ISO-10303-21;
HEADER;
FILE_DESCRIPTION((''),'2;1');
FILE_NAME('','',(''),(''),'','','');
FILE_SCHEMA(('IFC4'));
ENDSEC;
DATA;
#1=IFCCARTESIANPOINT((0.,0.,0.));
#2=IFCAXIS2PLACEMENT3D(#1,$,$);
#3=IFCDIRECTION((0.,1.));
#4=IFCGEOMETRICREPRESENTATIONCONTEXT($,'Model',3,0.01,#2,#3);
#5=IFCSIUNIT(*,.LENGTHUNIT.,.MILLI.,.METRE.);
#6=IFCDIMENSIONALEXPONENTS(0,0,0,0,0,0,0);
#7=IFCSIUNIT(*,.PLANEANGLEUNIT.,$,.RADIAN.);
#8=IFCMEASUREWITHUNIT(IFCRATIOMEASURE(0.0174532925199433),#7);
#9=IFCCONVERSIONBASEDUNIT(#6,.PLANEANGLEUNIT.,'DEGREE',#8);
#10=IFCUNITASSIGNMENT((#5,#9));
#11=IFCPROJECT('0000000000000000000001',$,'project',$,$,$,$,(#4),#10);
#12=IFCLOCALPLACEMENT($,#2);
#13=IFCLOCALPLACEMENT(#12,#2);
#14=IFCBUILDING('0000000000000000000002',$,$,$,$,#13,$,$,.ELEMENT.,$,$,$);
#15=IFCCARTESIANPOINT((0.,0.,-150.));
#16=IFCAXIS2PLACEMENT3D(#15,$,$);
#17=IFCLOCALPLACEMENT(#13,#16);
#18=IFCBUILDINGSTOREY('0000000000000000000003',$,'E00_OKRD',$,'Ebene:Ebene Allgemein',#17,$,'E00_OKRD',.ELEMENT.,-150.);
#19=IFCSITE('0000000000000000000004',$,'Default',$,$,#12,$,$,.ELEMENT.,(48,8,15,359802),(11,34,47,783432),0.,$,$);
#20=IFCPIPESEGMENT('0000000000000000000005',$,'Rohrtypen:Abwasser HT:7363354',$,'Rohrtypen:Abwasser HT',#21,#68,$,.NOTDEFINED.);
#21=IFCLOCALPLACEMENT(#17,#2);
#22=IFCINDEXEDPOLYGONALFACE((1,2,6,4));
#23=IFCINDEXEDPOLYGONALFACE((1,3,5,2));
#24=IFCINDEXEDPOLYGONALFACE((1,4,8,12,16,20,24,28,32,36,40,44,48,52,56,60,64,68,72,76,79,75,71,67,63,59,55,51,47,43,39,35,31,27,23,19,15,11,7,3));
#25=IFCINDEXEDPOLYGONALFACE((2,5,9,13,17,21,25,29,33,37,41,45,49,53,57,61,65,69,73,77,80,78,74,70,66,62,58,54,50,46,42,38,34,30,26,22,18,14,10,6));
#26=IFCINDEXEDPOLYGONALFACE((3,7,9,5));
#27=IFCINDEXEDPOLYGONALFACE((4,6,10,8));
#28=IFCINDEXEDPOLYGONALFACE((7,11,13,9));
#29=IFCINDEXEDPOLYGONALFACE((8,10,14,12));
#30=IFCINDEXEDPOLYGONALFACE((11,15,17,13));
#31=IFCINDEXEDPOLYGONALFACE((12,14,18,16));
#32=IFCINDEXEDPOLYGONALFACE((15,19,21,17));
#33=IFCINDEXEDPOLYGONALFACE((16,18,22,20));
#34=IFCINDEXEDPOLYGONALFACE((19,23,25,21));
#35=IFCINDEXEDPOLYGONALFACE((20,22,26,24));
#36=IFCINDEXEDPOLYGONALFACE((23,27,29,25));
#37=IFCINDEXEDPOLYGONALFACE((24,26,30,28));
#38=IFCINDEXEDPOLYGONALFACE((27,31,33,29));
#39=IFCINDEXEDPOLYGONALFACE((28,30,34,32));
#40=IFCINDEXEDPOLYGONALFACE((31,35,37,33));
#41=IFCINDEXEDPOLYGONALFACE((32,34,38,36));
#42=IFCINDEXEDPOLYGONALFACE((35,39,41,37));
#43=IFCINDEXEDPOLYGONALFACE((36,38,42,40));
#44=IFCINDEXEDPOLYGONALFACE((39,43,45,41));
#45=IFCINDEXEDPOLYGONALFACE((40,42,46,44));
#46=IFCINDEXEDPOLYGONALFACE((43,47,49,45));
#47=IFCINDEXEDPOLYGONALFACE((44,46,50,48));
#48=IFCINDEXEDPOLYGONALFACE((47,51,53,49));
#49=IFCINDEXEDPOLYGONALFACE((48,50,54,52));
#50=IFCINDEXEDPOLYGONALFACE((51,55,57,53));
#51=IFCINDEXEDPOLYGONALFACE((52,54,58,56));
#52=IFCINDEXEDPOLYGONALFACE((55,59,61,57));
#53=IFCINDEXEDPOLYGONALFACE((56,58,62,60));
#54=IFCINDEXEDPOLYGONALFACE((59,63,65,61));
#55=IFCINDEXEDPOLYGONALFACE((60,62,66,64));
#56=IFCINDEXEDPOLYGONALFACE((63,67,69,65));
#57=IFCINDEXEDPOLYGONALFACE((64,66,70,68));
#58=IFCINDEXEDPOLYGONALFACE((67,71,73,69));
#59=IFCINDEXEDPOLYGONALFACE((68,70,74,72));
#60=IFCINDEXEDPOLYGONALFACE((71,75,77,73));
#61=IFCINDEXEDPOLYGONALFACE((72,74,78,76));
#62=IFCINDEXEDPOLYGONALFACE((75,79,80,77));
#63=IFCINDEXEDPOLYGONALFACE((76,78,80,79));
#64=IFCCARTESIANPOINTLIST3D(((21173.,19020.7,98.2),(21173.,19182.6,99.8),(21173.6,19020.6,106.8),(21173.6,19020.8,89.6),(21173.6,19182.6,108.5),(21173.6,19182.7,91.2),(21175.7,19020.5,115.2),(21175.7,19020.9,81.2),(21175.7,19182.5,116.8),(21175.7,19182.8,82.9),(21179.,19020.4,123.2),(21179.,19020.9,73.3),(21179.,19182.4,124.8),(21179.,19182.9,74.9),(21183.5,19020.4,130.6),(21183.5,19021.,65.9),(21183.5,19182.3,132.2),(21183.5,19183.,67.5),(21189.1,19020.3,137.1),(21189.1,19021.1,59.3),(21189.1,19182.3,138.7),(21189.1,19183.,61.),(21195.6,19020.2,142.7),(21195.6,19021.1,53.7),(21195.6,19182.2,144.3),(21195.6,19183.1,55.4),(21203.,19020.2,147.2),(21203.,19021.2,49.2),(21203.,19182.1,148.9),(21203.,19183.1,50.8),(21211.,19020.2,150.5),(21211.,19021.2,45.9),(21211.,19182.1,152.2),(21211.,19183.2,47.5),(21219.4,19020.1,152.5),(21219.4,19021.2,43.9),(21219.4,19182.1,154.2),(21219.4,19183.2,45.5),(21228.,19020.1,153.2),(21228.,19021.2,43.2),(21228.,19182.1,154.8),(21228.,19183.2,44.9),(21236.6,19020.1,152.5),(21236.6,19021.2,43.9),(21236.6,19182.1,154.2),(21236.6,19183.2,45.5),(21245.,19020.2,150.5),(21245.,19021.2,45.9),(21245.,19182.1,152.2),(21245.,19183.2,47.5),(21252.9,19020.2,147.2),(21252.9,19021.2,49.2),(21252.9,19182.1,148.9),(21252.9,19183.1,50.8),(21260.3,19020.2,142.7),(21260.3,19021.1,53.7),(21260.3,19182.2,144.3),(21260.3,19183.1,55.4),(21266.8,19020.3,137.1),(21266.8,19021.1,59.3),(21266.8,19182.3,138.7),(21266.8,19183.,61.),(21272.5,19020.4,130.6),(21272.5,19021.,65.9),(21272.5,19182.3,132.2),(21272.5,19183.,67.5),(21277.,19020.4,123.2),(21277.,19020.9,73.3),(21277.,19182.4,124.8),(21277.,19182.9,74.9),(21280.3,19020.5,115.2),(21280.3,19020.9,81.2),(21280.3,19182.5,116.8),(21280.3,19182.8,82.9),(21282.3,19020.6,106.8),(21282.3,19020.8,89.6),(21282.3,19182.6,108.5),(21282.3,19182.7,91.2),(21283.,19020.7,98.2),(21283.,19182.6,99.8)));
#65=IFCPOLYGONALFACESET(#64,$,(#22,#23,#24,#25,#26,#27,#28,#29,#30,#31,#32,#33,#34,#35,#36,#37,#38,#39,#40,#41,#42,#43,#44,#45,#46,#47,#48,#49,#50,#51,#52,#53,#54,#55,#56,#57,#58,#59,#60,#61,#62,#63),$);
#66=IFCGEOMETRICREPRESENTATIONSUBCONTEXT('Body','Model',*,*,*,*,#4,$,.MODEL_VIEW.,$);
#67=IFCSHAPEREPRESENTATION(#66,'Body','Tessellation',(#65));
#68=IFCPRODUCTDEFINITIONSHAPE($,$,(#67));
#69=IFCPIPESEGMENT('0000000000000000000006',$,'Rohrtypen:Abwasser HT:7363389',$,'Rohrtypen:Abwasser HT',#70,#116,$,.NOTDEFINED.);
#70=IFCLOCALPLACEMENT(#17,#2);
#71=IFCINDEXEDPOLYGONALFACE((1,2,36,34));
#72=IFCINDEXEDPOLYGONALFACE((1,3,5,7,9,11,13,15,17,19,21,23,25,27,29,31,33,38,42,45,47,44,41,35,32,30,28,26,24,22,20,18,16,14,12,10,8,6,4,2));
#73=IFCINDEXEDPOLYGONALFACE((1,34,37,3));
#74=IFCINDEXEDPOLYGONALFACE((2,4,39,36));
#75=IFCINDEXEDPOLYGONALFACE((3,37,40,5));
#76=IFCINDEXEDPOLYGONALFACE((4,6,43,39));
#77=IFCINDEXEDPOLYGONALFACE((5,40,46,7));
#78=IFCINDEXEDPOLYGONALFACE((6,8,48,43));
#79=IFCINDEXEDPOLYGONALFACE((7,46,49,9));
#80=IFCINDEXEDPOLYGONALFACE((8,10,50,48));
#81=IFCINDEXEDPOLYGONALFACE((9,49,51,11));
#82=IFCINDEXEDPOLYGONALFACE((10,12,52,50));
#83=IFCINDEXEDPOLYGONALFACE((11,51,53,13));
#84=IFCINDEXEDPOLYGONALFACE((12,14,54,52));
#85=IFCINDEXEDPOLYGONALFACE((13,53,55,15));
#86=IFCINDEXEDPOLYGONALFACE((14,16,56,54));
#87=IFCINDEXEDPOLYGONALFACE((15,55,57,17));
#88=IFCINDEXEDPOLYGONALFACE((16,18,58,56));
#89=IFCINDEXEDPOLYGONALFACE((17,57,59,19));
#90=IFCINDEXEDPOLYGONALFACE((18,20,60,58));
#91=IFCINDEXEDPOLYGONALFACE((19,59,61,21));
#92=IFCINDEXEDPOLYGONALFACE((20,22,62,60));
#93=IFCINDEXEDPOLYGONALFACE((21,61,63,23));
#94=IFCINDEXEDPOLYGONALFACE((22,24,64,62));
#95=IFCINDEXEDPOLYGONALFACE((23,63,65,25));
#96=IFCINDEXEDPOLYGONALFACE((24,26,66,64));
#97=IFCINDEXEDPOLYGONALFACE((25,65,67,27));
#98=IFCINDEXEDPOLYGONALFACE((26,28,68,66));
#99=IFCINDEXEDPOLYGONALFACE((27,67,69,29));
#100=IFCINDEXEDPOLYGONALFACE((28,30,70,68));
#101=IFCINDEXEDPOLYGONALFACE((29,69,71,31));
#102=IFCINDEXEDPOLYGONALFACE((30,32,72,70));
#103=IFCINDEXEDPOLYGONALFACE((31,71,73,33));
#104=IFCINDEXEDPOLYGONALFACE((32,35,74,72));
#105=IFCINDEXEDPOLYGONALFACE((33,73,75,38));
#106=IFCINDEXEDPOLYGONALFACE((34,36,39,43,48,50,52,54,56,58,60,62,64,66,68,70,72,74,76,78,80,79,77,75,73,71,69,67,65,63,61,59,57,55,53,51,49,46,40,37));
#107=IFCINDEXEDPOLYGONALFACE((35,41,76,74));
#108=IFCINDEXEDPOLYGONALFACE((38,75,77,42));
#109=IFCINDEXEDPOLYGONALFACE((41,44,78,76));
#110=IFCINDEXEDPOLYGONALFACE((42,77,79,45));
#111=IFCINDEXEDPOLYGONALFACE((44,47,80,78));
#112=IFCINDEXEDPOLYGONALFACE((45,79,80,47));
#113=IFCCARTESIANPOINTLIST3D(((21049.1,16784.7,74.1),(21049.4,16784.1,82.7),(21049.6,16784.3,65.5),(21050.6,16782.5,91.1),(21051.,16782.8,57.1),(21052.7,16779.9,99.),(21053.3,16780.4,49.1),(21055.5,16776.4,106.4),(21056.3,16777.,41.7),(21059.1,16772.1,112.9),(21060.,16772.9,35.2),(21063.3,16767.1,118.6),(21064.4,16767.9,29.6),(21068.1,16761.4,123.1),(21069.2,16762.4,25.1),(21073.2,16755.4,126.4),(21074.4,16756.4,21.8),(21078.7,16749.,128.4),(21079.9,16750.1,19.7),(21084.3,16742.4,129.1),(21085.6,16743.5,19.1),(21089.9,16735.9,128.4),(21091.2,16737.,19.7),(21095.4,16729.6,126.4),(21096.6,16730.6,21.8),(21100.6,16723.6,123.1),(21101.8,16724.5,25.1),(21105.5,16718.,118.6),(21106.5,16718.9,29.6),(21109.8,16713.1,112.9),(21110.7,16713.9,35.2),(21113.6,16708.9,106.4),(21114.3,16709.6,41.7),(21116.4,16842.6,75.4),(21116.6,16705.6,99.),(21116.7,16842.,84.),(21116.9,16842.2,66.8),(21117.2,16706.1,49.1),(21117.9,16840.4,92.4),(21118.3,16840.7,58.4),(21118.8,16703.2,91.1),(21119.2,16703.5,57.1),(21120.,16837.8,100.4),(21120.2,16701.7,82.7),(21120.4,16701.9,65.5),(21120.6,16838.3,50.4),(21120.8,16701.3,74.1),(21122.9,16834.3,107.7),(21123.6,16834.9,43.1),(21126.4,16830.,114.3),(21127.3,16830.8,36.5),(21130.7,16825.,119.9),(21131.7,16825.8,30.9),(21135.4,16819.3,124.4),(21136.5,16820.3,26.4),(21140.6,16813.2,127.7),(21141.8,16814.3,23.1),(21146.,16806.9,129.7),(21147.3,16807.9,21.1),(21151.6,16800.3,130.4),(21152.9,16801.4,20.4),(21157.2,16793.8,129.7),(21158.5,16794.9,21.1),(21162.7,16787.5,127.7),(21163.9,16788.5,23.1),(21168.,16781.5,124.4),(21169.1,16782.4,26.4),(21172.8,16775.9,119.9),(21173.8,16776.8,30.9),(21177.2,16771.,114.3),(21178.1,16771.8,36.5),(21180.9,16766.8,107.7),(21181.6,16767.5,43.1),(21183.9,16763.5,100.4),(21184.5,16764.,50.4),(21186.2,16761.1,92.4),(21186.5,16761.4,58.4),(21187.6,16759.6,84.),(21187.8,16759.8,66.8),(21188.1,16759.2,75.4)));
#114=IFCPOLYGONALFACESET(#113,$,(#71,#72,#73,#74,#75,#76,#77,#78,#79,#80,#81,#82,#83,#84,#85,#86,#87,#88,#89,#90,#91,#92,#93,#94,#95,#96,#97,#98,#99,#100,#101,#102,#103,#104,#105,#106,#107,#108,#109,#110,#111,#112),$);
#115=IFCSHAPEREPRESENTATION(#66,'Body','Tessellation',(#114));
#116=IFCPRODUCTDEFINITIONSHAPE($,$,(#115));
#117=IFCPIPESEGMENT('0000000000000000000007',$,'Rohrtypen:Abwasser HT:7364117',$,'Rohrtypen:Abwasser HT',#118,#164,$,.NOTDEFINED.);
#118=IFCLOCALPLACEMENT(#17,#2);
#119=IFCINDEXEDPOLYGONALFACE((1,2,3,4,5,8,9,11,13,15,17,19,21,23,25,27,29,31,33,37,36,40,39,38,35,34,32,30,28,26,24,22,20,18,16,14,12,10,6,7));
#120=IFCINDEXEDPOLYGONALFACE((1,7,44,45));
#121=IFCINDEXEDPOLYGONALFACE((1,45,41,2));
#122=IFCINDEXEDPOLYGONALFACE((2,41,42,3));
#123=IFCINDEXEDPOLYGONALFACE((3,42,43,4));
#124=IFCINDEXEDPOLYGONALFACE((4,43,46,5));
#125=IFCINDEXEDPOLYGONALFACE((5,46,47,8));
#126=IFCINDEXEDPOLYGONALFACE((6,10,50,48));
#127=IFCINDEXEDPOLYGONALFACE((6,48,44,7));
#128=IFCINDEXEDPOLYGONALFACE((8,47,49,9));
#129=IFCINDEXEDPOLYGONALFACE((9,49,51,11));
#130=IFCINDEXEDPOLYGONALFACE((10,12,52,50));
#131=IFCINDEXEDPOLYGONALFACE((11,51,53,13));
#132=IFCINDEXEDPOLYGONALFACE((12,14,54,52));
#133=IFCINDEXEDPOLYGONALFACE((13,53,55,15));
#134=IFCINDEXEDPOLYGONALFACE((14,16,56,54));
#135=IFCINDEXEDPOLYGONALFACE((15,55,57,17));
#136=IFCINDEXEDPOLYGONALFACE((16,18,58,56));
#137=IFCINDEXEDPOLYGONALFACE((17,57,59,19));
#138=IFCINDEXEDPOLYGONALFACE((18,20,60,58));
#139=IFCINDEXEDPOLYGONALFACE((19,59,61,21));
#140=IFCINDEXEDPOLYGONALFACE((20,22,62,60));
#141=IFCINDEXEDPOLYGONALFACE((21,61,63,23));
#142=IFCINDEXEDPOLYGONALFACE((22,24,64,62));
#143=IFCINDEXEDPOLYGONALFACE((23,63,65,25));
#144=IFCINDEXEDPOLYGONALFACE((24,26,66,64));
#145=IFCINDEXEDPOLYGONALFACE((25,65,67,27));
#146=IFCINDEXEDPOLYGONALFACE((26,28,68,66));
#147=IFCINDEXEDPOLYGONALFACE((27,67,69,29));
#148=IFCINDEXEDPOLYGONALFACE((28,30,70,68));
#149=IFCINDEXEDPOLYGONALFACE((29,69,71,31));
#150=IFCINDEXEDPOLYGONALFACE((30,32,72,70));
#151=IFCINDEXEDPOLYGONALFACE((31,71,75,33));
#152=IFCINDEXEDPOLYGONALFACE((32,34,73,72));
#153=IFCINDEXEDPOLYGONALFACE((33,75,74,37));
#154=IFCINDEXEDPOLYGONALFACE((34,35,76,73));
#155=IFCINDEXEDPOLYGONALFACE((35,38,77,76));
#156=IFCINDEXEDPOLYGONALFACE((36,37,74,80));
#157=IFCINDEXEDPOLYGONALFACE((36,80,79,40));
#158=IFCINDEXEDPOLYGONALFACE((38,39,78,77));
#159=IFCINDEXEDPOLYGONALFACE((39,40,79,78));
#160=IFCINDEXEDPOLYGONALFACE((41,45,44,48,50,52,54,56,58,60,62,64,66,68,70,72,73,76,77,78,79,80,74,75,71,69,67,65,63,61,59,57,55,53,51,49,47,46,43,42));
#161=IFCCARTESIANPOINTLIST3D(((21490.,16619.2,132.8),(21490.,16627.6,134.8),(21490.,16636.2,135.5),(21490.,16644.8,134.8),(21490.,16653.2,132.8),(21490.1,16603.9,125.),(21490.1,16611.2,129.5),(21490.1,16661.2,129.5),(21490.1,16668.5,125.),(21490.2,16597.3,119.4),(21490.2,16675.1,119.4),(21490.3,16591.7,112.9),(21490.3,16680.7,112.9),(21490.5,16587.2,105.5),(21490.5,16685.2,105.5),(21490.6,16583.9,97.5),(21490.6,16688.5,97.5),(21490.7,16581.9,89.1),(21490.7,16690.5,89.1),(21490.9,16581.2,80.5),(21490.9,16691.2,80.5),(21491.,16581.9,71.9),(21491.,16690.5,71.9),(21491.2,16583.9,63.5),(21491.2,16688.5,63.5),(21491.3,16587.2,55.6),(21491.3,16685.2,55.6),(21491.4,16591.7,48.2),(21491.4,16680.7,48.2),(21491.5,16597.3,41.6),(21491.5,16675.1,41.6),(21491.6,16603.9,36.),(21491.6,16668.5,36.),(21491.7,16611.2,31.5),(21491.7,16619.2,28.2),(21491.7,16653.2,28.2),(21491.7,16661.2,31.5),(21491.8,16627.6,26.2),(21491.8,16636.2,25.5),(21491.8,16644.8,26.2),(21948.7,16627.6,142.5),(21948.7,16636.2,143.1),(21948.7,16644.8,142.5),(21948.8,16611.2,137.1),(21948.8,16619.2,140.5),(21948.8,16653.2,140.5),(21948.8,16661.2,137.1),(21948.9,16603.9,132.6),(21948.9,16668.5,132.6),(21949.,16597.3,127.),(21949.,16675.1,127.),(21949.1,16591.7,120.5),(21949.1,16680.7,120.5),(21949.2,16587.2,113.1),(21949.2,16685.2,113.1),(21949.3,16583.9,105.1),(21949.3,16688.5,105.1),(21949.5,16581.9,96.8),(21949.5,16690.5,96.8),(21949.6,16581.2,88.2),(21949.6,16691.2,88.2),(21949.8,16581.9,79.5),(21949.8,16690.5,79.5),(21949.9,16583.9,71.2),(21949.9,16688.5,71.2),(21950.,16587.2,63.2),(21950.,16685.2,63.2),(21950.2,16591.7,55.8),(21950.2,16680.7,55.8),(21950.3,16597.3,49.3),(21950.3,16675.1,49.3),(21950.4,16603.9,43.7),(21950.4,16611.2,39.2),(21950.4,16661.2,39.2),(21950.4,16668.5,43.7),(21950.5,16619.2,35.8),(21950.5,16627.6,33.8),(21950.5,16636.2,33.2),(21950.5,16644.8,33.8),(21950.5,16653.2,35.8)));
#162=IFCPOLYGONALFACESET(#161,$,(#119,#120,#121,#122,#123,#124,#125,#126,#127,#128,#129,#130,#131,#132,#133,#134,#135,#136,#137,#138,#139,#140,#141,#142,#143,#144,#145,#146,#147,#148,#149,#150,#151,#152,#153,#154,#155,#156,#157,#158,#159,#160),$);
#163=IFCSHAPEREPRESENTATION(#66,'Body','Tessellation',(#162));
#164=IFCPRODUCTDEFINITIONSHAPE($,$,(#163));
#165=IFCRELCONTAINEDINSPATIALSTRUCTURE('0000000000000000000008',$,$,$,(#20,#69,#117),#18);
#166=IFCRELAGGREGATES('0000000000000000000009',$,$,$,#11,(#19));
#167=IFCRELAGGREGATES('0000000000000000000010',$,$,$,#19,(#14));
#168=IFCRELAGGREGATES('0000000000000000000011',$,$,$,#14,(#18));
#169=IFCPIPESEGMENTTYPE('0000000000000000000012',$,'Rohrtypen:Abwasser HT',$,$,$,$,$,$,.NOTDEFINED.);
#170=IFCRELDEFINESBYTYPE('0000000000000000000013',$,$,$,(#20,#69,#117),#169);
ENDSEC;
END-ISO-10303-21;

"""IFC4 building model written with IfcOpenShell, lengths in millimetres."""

from ifc_helpers import new_model, entity, si_unit, converted_unit, direction, frame, origin, place, context, subcontext, project, spatial, indexed_curve, outline, extrude, type_object, element, save


model = new_model("IFC4")

# Units and contexts
model_context = context("Model", 3, precision=0.01, world=origin(), true_north=direction((0.0, 1.0)))
body_context = subcontext(model_context, "Body", "Model", "MODEL_VIEW")
ifc_project = project(units=[si_unit("LENGTHUNIT", "METRE", prefix="MILLI"), converted_unit("PLANEANGLEUNIT", "DEGREE", entity("IfcRatioMeasure", 0.0174532925199433), si_unit("PLANEANGLEUNIT", "RADIAN"), dimensions=[0, 0, 0, 0, 0, 0, 0])], contexts=[model_context])

# Site, building, storey
site_placement = place(None, origin())
site = spatial("IfcSite", under=ifc_project, at=site_placement, Name="Default", CompositionType="ELEMENT", RefLatitude=(48, 8, 15, 359802), RefLongitude=(11, 34, 47, 783432), RefElevation=0.0)
building_placement = place(site_placement, origin())
building = spatial("IfcBuilding", under=site, at=building_placement, CompositionType="ELEMENT")
storey_placement = place(building_placement, frame((0.0, 0.0, -150.0)))
storey = spatial("IfcBuildingStorey", under=building, at=storey_placement, Name="E00_OKRD", ObjectType="Ebene:Ebene Allgemein", LongName="E00_OKRD", CompositionType="ELEMENT", Elevation=-150.0)

# Pipe segments
pipe_segment_type_1 = type_object("IfcPipeSegmentType", Name="Rohrtypen:Abwasser HT", PredefinedType="NOTDEFINED")
pipe_segment_1_placement = place(storey_placement, origin())
element("IfcPipeSegment", 1, at=pipe_segment_1_placement, inside=storey, type_object=pipe_segment_type_1, Name="Rohrtypen:Abwasser HT:7363354", ObjectType="Rohrtypen:Abwasser HT", PredefinedType="NOTDEFINED", context=body_context, shape_type="SweptSolid", body=[
    extrude(outline(indexed_curve([(55.0, 0.0), (54.3, 8.6), (52.3, 17.0), (49.0, 25.0), (44.5, 32.3), (38.9, 38.9), (32.3, 44.5), (25.0, 49.0), (17.0, 52.3), (8.6, 54.3), (0.0, 55.0), (-8.6, 54.3), (-17.0, 52.3), (-25.0, 49.0), (-32.3, 44.5), (-38.9, 38.9), (-44.5, 32.3), (-49.0, 25.0), (-52.3, 17.0), (-54.3, 8.6), (-55.0, 0.0), (-54.3, -8.6), (-52.3, -17.0), (-49.0, -25.0), (-44.5, -32.3), (-38.9, -38.9), (-32.3, -44.5), (-25.0, -49.0), (-17.0, -52.3), (-8.6, -54.3), (0.0, -55.0), (8.6, -54.3), (17.0, -52.3), (25.0, -49.0), (32.3, -44.5), (38.9, -38.9), (44.5, -32.3), (49.0, -25.0), (52.3, -17.0), (54.3, -8.6), (55.0, 0.0)], self_intersect=False)), frame((21228.0, 19020.7, 98.2), z_axis=(0.0, 0.99995, 0.01), x_axis=(1.0, 0.0, 0.0)), (0.0, 0.0, 1.0), 162.0),
])
pipe_segment_2_placement = place(storey_placement, origin())
element("IfcPipeSegment", 2, at=pipe_segment_2_placement, inside=storey, type_object=pipe_segment_type_1, Name="Rohrtypen:Abwasser HT:7363389", ObjectType="Rohrtypen:Abwasser HT", PredefinedType="NOTDEFINED", context=body_context, shape_type="SweptSolid", body=[
    extrude(outline(indexed_curve([(55.0, 0.0), (54.3, 8.6), (52.3, 17.0), (49.0, 25.0), (44.5, 32.3), (38.9, 38.9), (32.3, 44.5), (25.0, 49.0), (17.0, 52.3), (8.6, 54.3), (0.0, 55.0), (-8.6, 54.3), (-17.0, 52.3), (-25.0, 49.0), (-32.3, 44.5), (-38.9, 38.9), (-44.5, 32.3), (-49.0, 25.0), (-52.3, 17.0), (-54.3, 8.6), (-55.0, 0.0), (-54.3, -8.6), (-52.3, -17.0), (-49.0, -25.0), (-44.5, -32.3), (-38.9, -38.9), (-32.3, -44.5), (-25.0, -49.0), (-17.0, -52.3), (-8.6, -54.3), (0.0, -55.0), (8.6, -54.3), (17.0, -52.3), (25.0, -49.0), (32.3, -44.5), (38.9, -38.9), (44.5, -32.3), (49.0, -25.0), (52.3, -17.0), (54.3, -8.6), (55.0, 0.0)], self_intersect=False)), frame((21084.9, 16743.0, 74.1), z_axis=(0.758154, 0.651898, 0.015231), x_axis=(-0.651974, 0.758242, 0.0)), (0.0, 0.0, 1.0), 88.8),
])
pipe_segment_3_placement = place(storey_placement, origin())
element("IfcPipeSegment", 3, at=pipe_segment_3_placement, inside=storey, type_object=pipe_segment_type_1, Name="Rohrtypen:Abwasser HT:7364117", ObjectType="Rohrtypen:Abwasser HT", PredefinedType="NOTDEFINED", context=body_context, shape_type="SweptSolid", body=[
    extrude(outline(indexed_curve([(55.0, 0.0), (54.3, 8.6), (52.3, 17.0), (49.0, 25.0), (44.5, 32.3), (38.9, 38.9), (32.3, 44.5), (25.0, 49.0), (17.0, 52.3), (8.6, 54.3), (0.0, 55.0), (-8.6, 54.3), (-17.0, 52.3), (-25.0, 49.0), (-32.3, 44.5), (-38.9, 38.9), (-44.5, 32.3), (-49.0, 25.0), (-52.3, 17.0), (-54.3, 8.6), (-55.0, 0.0), (-54.3, -8.6), (-52.3, -17.0), (-49.0, -25.0), (-44.5, -32.3), (-38.9, -38.9), (-32.3, -44.5), (-25.0, -49.0), (-17.0, -52.3), (-8.6, -54.3), (0.0, -55.0), (8.6, -54.3), (17.0, -52.3), (25.0, -49.0), (32.3, -44.5), (38.9, -38.9), (44.5, -32.3), (49.0, -25.0), (52.3, -17.0), (54.3, -8.6), (55.0, 0.0)], self_intersect=False)), frame((21490.9, 16636.2, 80.5), z_axis=(0.999862, 0.0, 0.016604), x_axis=(0.0, 1.0, 0.0)), (0.0, 0.0, 1.0), 458.8),
])

save(model, "model.ifc")
